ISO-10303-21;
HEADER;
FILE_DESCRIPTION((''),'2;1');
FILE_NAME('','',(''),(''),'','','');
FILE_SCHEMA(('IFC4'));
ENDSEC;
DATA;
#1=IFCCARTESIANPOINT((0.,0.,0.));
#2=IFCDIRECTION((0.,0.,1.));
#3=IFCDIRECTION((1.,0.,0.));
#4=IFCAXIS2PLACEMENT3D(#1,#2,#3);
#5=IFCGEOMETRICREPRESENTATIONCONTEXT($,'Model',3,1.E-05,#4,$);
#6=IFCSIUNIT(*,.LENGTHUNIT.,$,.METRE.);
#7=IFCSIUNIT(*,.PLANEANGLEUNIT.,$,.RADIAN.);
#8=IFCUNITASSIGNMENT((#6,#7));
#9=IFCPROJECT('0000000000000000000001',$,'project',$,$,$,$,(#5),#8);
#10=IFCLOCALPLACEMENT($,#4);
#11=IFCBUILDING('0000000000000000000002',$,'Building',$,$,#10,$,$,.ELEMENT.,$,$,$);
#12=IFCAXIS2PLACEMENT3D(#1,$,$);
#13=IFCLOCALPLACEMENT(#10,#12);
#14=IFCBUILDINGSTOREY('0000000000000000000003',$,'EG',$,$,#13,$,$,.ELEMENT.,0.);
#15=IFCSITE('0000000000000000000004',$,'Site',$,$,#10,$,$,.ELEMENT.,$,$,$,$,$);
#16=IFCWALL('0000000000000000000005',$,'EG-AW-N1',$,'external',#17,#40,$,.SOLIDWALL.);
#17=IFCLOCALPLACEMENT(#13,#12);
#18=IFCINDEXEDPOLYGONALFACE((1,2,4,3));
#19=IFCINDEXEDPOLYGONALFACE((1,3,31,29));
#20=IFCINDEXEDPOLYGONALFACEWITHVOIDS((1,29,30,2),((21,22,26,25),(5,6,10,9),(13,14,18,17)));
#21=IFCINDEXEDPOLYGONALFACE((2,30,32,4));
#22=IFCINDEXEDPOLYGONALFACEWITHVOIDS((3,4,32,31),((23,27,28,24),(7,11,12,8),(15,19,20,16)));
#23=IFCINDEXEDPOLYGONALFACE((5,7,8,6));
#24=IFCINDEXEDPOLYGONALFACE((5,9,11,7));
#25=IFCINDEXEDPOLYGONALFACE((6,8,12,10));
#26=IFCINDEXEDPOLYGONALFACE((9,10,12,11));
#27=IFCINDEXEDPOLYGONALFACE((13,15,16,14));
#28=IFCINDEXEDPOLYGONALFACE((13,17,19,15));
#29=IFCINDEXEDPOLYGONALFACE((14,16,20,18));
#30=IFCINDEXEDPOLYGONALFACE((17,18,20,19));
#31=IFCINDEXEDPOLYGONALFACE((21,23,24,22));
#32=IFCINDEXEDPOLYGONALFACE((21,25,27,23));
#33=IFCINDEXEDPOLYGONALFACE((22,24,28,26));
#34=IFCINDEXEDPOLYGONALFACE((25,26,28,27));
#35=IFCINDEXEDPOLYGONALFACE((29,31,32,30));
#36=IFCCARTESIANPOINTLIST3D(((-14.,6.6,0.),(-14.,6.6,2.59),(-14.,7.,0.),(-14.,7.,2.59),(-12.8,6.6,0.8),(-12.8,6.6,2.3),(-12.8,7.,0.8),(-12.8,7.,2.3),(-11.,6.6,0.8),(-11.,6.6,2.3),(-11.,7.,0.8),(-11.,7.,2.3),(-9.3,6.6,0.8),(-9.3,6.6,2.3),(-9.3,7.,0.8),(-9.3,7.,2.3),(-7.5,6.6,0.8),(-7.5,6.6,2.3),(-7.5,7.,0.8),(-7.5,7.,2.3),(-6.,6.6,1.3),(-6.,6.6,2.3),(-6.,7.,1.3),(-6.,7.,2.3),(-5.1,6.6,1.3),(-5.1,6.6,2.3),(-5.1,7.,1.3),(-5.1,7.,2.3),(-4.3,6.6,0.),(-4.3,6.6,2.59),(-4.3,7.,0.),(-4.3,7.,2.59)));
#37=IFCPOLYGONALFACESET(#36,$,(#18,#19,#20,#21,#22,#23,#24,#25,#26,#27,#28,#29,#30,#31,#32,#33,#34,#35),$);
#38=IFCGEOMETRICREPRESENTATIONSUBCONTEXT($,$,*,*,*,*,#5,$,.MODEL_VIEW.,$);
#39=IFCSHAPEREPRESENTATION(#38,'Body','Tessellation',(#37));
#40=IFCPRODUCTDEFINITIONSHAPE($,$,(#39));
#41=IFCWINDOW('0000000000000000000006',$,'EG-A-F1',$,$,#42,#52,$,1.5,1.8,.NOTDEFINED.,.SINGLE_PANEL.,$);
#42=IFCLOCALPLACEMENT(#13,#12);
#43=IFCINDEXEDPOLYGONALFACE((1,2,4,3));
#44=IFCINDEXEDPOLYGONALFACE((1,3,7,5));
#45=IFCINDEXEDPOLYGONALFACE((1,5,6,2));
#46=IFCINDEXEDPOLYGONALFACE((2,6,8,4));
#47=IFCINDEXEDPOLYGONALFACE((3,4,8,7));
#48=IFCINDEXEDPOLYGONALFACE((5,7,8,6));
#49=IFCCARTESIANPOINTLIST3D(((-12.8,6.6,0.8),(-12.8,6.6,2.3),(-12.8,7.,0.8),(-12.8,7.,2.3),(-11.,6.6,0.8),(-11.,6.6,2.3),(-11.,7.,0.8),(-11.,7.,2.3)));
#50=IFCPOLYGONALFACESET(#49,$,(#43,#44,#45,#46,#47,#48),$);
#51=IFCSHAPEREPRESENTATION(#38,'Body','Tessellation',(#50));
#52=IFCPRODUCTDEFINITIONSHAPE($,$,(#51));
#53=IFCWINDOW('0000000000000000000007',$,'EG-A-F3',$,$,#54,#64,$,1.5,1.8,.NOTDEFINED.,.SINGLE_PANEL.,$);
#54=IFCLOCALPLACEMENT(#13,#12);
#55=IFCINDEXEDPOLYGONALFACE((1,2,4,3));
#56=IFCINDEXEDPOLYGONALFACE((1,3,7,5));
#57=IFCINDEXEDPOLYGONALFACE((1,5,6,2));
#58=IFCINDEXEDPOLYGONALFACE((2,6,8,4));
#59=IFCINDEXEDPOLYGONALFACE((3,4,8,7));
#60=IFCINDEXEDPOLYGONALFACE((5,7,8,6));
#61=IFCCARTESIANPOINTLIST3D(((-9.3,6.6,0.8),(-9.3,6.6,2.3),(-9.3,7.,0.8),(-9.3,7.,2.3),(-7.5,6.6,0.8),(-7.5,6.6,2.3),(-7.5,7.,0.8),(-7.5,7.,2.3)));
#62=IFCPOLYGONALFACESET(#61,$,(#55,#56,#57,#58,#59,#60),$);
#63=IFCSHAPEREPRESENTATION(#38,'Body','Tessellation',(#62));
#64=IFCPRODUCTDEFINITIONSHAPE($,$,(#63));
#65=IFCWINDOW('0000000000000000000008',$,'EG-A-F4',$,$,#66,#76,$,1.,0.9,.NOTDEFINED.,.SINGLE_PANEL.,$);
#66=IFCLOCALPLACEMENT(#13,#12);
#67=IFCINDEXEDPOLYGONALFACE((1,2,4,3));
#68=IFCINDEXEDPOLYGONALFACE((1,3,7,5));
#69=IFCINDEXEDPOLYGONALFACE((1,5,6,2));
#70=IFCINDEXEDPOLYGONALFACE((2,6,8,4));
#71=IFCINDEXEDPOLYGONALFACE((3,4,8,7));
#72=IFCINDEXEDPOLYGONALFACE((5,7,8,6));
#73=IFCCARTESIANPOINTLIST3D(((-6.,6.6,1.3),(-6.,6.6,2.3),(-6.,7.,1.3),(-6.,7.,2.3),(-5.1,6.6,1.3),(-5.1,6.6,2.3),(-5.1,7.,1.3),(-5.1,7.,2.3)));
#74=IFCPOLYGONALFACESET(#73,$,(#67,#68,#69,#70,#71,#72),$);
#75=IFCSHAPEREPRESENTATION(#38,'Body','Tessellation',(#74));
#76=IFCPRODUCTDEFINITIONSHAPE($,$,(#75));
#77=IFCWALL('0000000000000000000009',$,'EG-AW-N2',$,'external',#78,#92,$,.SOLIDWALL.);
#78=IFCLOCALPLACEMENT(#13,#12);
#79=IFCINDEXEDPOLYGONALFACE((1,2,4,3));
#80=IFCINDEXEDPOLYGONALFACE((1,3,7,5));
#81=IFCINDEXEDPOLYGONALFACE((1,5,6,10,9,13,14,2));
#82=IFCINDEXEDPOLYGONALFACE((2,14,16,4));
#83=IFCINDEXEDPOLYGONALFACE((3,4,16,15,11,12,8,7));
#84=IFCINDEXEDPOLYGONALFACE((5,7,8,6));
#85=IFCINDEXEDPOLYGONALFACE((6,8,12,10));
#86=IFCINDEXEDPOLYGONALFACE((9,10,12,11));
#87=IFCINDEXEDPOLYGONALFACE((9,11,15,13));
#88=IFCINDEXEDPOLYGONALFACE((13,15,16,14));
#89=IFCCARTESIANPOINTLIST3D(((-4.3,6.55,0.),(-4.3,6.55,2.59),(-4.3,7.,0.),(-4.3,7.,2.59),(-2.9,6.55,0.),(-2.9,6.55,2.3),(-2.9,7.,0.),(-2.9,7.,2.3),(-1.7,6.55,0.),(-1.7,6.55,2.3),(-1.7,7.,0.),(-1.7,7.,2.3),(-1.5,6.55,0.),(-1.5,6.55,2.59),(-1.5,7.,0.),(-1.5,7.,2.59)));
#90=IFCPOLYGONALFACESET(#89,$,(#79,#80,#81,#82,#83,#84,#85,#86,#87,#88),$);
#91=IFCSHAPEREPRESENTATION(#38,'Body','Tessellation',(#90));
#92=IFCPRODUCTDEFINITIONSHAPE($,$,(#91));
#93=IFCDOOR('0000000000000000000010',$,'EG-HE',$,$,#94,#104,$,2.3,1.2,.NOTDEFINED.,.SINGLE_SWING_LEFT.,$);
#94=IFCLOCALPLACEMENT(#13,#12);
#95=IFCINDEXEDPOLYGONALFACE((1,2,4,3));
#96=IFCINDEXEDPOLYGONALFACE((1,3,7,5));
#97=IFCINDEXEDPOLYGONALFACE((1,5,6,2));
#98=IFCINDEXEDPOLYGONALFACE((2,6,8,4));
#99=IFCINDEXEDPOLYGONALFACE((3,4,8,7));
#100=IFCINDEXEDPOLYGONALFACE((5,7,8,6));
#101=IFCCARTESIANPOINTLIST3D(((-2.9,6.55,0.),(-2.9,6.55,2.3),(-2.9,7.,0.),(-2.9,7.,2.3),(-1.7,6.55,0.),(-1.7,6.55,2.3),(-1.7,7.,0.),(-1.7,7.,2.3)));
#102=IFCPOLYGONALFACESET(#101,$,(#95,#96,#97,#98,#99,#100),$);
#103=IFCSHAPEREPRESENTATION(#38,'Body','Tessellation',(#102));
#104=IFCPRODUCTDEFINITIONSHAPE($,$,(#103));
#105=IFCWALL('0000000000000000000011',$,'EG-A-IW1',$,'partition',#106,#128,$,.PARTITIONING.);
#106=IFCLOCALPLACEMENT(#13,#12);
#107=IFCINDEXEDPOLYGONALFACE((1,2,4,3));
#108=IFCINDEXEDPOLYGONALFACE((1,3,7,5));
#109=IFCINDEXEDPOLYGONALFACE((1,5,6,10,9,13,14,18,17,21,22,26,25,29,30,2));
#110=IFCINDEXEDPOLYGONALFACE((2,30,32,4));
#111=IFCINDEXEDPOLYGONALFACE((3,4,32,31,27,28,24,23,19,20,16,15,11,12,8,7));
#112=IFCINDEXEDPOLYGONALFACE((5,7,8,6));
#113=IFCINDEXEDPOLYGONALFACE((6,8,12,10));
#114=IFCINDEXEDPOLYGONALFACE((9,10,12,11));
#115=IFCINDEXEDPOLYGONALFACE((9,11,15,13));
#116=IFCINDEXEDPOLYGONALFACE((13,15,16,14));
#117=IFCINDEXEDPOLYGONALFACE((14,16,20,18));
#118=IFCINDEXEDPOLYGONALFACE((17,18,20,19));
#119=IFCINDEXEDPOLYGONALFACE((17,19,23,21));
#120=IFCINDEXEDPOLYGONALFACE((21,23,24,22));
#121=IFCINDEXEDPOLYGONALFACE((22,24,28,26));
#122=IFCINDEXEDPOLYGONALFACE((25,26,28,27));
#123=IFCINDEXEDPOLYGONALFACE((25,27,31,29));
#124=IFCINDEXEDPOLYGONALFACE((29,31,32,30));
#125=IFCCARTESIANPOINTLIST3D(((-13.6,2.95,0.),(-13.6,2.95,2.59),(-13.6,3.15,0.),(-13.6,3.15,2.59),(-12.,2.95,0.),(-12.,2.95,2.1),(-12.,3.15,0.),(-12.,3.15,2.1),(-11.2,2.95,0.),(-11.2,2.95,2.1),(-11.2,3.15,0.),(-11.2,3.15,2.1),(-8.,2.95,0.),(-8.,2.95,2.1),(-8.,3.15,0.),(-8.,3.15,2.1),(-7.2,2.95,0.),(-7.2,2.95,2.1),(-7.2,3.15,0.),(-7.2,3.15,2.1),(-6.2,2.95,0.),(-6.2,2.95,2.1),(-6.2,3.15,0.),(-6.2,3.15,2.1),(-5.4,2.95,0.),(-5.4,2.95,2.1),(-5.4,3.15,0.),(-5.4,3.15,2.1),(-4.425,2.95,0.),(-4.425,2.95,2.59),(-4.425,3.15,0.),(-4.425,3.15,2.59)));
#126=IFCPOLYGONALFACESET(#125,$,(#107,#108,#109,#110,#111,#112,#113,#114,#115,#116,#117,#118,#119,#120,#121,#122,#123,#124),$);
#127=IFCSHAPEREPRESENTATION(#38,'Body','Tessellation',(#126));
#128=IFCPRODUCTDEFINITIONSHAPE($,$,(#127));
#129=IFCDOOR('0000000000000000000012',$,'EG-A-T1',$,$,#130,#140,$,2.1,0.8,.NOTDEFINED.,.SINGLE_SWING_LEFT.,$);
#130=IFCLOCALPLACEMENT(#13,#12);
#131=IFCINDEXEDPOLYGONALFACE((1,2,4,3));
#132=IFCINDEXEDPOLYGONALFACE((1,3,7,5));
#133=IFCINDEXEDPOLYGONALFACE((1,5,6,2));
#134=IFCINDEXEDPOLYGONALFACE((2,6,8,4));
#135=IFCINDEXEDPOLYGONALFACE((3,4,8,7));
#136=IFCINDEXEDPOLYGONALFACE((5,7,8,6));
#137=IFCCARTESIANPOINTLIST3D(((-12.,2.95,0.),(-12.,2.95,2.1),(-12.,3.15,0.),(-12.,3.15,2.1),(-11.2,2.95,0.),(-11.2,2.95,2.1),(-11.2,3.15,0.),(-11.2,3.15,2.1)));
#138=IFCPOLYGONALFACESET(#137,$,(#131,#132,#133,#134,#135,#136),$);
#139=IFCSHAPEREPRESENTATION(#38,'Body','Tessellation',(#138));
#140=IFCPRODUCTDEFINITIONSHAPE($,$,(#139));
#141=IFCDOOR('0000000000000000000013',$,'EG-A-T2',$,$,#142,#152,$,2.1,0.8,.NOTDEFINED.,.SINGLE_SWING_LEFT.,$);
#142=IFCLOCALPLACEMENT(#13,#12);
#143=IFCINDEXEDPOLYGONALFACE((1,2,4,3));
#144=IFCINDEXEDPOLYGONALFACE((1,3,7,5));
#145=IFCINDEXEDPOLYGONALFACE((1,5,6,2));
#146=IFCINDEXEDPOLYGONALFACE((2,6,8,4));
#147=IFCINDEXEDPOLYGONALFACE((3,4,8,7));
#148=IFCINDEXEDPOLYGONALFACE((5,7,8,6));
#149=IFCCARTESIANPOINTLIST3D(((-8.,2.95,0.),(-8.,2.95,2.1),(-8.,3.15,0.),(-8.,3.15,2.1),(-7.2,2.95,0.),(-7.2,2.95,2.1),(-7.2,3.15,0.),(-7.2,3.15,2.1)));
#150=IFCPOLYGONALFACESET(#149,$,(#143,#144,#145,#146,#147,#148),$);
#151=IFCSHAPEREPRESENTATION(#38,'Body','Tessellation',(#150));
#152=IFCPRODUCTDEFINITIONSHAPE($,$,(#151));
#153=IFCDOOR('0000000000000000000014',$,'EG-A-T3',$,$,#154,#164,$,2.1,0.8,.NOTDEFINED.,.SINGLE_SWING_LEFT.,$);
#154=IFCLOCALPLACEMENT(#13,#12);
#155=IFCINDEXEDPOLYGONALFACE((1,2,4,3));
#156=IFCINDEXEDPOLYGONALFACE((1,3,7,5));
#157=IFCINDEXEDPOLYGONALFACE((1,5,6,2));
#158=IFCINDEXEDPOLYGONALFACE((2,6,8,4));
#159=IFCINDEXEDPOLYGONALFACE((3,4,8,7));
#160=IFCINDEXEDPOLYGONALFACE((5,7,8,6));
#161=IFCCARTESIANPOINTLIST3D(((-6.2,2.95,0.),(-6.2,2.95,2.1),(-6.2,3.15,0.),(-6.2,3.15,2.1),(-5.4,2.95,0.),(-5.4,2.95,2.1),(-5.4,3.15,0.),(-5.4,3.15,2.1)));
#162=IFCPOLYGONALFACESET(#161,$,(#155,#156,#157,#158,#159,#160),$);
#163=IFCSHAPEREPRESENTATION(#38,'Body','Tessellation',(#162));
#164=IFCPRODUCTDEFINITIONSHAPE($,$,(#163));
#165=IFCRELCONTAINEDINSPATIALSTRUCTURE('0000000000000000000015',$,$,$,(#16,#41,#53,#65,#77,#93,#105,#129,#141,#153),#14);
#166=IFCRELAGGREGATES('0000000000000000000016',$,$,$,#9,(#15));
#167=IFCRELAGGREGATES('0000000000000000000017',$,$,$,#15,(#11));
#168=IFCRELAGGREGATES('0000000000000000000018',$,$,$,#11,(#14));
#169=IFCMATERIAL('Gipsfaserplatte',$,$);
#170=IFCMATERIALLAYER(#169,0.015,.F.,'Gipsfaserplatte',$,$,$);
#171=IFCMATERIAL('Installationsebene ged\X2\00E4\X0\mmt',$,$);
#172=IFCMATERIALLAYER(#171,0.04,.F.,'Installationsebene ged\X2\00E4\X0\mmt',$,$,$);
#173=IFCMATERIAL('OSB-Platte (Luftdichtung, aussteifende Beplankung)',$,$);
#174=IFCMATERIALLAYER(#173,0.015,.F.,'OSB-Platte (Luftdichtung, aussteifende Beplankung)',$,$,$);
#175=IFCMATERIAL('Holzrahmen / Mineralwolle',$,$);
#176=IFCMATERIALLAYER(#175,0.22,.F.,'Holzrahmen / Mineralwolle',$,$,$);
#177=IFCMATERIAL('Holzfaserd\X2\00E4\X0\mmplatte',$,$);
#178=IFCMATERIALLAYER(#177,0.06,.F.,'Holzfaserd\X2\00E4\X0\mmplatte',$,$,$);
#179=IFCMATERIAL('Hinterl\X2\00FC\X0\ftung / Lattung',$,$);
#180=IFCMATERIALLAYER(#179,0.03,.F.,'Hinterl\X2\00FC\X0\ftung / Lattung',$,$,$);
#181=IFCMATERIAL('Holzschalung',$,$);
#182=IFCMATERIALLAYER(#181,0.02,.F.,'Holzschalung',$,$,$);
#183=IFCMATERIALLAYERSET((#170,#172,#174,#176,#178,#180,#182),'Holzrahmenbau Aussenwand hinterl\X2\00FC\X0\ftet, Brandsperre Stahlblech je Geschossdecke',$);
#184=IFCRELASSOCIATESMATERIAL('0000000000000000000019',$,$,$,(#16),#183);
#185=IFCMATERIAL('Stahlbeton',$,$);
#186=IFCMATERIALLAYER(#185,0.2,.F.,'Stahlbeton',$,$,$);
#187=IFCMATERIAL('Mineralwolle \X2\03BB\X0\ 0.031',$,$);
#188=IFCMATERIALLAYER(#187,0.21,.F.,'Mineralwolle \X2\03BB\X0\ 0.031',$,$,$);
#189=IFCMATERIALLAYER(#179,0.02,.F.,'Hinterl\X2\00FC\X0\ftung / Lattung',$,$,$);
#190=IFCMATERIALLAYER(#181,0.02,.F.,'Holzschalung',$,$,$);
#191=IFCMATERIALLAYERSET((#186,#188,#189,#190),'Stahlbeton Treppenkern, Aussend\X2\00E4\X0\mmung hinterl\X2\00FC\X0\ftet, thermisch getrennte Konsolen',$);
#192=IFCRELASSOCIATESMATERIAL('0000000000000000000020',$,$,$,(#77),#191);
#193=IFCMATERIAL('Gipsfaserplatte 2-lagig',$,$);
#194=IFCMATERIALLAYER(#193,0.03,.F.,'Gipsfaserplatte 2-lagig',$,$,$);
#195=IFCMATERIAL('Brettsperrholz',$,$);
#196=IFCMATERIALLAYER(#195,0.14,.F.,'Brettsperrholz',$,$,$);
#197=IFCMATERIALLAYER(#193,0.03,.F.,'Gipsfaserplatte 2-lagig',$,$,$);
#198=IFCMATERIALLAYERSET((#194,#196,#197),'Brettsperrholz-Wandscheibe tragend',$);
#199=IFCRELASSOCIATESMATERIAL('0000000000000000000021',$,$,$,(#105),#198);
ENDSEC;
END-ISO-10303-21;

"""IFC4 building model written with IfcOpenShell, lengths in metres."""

from ifc_helpers import new_model, si_unit, frame, frame_2d, origin, origin_with_axes, place, context, subcontext, project, spatial, rectangle, extrude, material, layer, layer_set, element, fill, save


model = new_model("IFC4")

# Units and contexts
model_context = context("Model", 3, precision=1e-05, world=origin_with_axes())
sub_context = subcontext(model_context, None, None, "MODEL_VIEW")
ifc_project = project(units=[si_unit("LENGTHUNIT", "METRE"), si_unit("PLANEANGLEUNIT", "RADIAN")], contexts=[model_context])

# Site, building, storey
placement = place(None, origin_with_axes())
site = spatial("IfcSite", under=ifc_project, at=placement, Name="Site", CompositionType="ELEMENT")
building = spatial("IfcBuilding", under=site, at=placement, Name="Building", CompositionType="ELEMENT")
storey_placement = place(placement, origin())
storey = spatial("IfcBuildingStorey", under=building, at=storey_placement, Name="EG", CompositionType="ELEMENT", Elevation=0.0)

# Wall, openings, windows
ifc_material_1 = material(Name="Gipsfaserplatte")
ifc_layer_1 = layer(ifc_material_1, 0.015, ventilated=False, Name="Gipsfaserplatte")
ifc_material_2 = material(Name="Installationsebene gedämmt")
ifc_layer_2 = layer(ifc_material_2, 0.04, ventilated=False, Name="Installationsebene gedämmt")
ifc_material_3 = material(Name="OSB-Platte (Luftdichtung, aussteifende Beplankung)")
ifc_layer_3 = layer(ifc_material_3, 0.015, ventilated=False, Name="OSB-Platte (Luftdichtung, aussteifende Beplankung)")
ifc_material_4 = material(Name="Holzrahmen / Mineralwolle")
ifc_layer_4 = layer(ifc_material_4, 0.22, ventilated=False, Name="Holzrahmen / Mineralwolle")
ifc_material_5 = material(Name="Holzfaserdämmplatte")
ifc_layer_5 = layer(ifc_material_5, 0.06, ventilated=False, Name="Holzfaserdämmplatte")
ifc_material_6 = material(Name="Hinterlüftung / Lattung")
ifc_layer_6 = layer(ifc_material_6, 0.03, ventilated=False, Name="Hinterlüftung / Lattung")
ifc_material_7 = material(Name="Holzschalung")
ifc_layer_7 = layer(ifc_material_7, 0.02, ventilated=False, Name="Holzschalung")
ifc_layer_set_1 = layer_set([ifc_layer_1, ifc_layer_2, ifc_layer_3, ifc_layer_4, ifc_layer_5, ifc_layer_6, ifc_layer_7], Name="Holzrahmenbau Aussenwand hinterlüftet, Brandsperre Stahlblech je Geschossdecke")
wall_1_placement = place(storey_placement, frame((-14.0, 6.8, 0.0), z_axis=(0.0, 0.0, 1.0), x_axis=(1.0, 0.0, 0.0)))
wall_1 = element("IfcWall", 1, at=wall_1_placement, inside=storey, material=ifc_layer_set_1, Name="EG-AW-N1", ObjectType="external", PredefinedType="SOLIDWALL", context=sub_context, shape_type="SweptSolid", body=[
    extrude(rectangle(XDim=9.7, YDim=0.4, at=frame_2d((4.85, 0.0))), origin(), (0.0, 0.0, 1.0), 2.59),
])
opening_1_placement = place(wall_1_placement, frame((2.1, 0.25, 0.8), z_axis=(0.0, -1.0, 0.0), x_axis=(1.0, 0.0, 0.0)))
opening_1 = element("IfcOpeningElement", 2, at=opening_1_placement, cuts=wall_1, PredefinedType="OPENING", context=sub_context, shape_type="SweptSolid", body=[
    extrude(rectangle(XDim=1.8, YDim=1.5, at=frame_2d((0.0, 0.75))), origin(), (0.0, 0.0, 1.0), 0.5),
])
opening_2_placement = place(wall_1_placement, frame((5.6, 0.25, 0.8), z_axis=(0.0, -1.0, 0.0), x_axis=(1.0, 0.0, 0.0)))
opening_2 = element("IfcOpeningElement", 3, at=opening_2_placement, cuts=wall_1, PredefinedType="OPENING", context=sub_context, shape_type="SweptSolid", body=[
    extrude(rectangle(XDim=1.8, YDim=1.5, at=frame_2d((0.0, 0.75))), origin(), (0.0, 0.0, 1.0), 0.5),
])
opening_3_placement = place(wall_1_placement, frame((8.45, 0.25, 1.3), z_axis=(0.0, -1.0, 0.0), x_axis=(1.0, 0.0, 0.0)))
opening_3 = element("IfcOpeningElement", 4, at=opening_3_placement, cuts=wall_1, PredefinedType="OPENING", context=sub_context, shape_type="SweptSolid", body=[
    extrude(rectangle(XDim=0.9, YDim=1.0, at=frame_2d((0.0, 0.5))), origin(), (0.0, 0.0, 1.0), 0.5),
])
window_1_placement = place(wall_1_placement, frame((2.1, 0.2, 0.8), z_axis=(0.0, -1.0, 0.0), x_axis=(1.0, 0.0, 0.0)))
window_1 = element("IfcWindow", 5, at=window_1_placement, inside=storey, Name="EG-A-F1", OverallHeight=1.5, OverallWidth=1.8, PartitioningType="SINGLE_PANEL", PredefinedType="NOTDEFINED", context=sub_context, shape_type="SweptSolid", body=[
    extrude(rectangle(XDim=1.8, YDim=1.5, at=frame_2d((0.0, 0.75))), origin(), (0.0, 0.0, 1.0), 0.4),
])
fill(opening_1, window_1)
window_2_placement = place(wall_1_placement, frame((5.6, 0.2, 0.8), z_axis=(0.0, -1.0, 0.0), x_axis=(1.0, 0.0, 0.0)))
window_2 = element("IfcWindow", 6, at=window_2_placement, inside=storey, Name="EG-A-F3", OverallHeight=1.5, OverallWidth=1.8, PartitioningType="SINGLE_PANEL", PredefinedType="NOTDEFINED", context=sub_context, shape_type="SweptSolid", body=[
    extrude(rectangle(XDim=1.8, YDim=1.5, at=frame_2d((0.0, 0.75))), origin(), (0.0, 0.0, 1.0), 0.4),
])
fill(opening_2, window_2)
window_3_placement = place(wall_1_placement, frame((8.45, 0.2, 1.3), z_axis=(0.0, -1.0, 0.0), x_axis=(1.0, 0.0, 0.0)))
window_3 = element("IfcWindow", 7, at=window_3_placement, inside=storey, Name="EG-A-F4", OverallHeight=1.0, OverallWidth=0.9, PartitioningType="SINGLE_PANEL", PredefinedType="NOTDEFINED", context=sub_context, shape_type="SweptSolid", body=[
    extrude(rectangle(XDim=0.9, YDim=1.0, at=frame_2d((0.0, 0.5))), origin(), (0.0, 0.0, 1.0), 0.4),
])
fill(opening_3, window_3)

# Wall, opening, door
ifc_material_8 = material(Name="Stahlbeton")
ifc_layer_8 = layer(ifc_material_8, 0.2, ventilated=False, Name="Stahlbeton")
ifc_material_9 = material(Name="Mineralwolle λ 0.031")
ifc_layer_9 = layer(ifc_material_9, 0.21, ventilated=False, Name="Mineralwolle λ 0.031")
ifc_layer_10 = layer(ifc_material_6, 0.02, ventilated=False, Name="Hinterlüftung / Lattung")
ifc_layer_11 = layer(ifc_material_7, 0.02, ventilated=False, Name="Holzschalung")
ifc_layer_set_2 = layer_set([ifc_layer_8, ifc_layer_9, ifc_layer_10, ifc_layer_11], Name="Stahlbeton Treppenkern, Aussendämmung hinterlüftet, thermisch getrennte Konsolen")
wall_2_placement = place(storey_placement, frame((-4.3, 6.775, 0.0), z_axis=(0.0, 0.0, 1.0), x_axis=(1.0, 0.0, 0.0)))
wall_2 = element("IfcWall", 8, at=wall_2_placement, inside=storey, material=ifc_layer_set_2, Name="EG-AW-N2", ObjectType="external", PredefinedType="SOLIDWALL", context=sub_context, shape_type="SweptSolid", body=[
    extrude(rectangle(XDim=2.8, YDim=0.45, at=frame_2d((1.4, 0.0))), origin(), (0.0, 0.0, 1.0), 2.59),
])
opening_4_placement = place(wall_2_placement, frame((2.0, 0.275, 0.0), z_axis=(0.0, -1.0, 0.0), x_axis=(1.0, 0.0, 0.0)))
opening_4 = element("IfcOpeningElement", 9, at=opening_4_placement, cuts=wall_2, PredefinedType="OPENING", context=sub_context, shape_type="SweptSolid", body=[
    extrude(rectangle(XDim=1.2, YDim=2.3, at=frame_2d((0.0, 1.15))), origin(), (0.0, 0.0, 1.0), 0.55),
])
door_1_placement = place(wall_2_placement, frame((2.0, 0.225, 0.0), z_axis=(0.0, -1.0, 0.0), x_axis=(1.0, 0.0, 0.0)))
door_1 = element("IfcDoor", 10, at=door_1_placement, inside=storey, Name="EG-HE", OperationType="SINGLE_SWING_LEFT", OverallHeight=2.3, OverallWidth=1.2, PredefinedType="NOTDEFINED", context=sub_context, shape_type="SweptSolid", body=[
    extrude(rectangle(XDim=1.2, YDim=2.3, at=frame_2d((0.0, 1.15))), origin(), (0.0, 0.0, 1.0), 0.45),
])
fill(opening_4, door_1)

# Wall, openings, doors
ifc_material_10 = material(Name="Gipsfaserplatte 2-lagig")
ifc_layer_12 = layer(ifc_material_10, 0.03, ventilated=False, Name="Gipsfaserplatte 2-lagig")
ifc_material_11 = material(Name="Brettsperrholz")
ifc_layer_13 = layer(ifc_material_11, 0.14, ventilated=False, Name="Brettsperrholz")
ifc_layer_14 = layer(ifc_material_10, 0.03, ventilated=False, Name="Gipsfaserplatte 2-lagig")
ifc_layer_set_3 = layer_set([ifc_layer_12, ifc_layer_13, ifc_layer_14], Name="Brettsperrholz-Wandscheibe tragend")
wall_3_placement = place(storey_placement, frame((-13.6, 3.05, 0.0), z_axis=(0.0, 0.0, 1.0), x_axis=(1.0, 0.0, 0.0)))
wall_3 = element("IfcWall", 11, at=wall_3_placement, inside=storey, material=ifc_layer_set_3, Name="EG-A-IW1", ObjectType="partition", PredefinedType="PARTITIONING", context=sub_context, shape_type="SweptSolid", body=[
    extrude(rectangle(XDim=9.175, YDim=0.2, at=frame_2d((4.5875, 0.0))), origin(), (0.0, 0.0, 1.0), 2.59),
])
opening_5_placement = place(wall_3_placement, frame((2.0, 0.15, 0.0), z_axis=(0.0, -1.0, 0.0), x_axis=(1.0, 0.0, 0.0)))
opening_5 = element("IfcOpeningElement", 12, at=opening_5_placement, cuts=wall_3, PredefinedType="OPENING", context=sub_context, shape_type="SweptSolid", body=[
    extrude(rectangle(XDim=0.8, YDim=2.1, at=frame_2d((0.0, 1.05))), origin(), (0.0, 0.0, 1.0), 0.3),
])
opening_6_placement = place(wall_3_placement, frame((6.0, 0.15, 0.0), z_axis=(0.0, -1.0, 0.0), x_axis=(1.0, 0.0, 0.0)))
opening_6 = element("IfcOpeningElement", 13, at=opening_6_placement, cuts=wall_3, PredefinedType="OPENING", context=sub_context, shape_type="SweptSolid", body=[
    extrude(rectangle(XDim=0.8, YDim=2.1, at=frame_2d((0.0, 1.05))), origin(), (0.0, 0.0, 1.0), 0.3),
])
opening_7_placement = place(wall_3_placement, frame((7.8, 0.15, 0.0), z_axis=(0.0, -1.0, 0.0), x_axis=(1.0, 0.0, 0.0)))
opening_7 = element("IfcOpeningElement", 14, at=opening_7_placement, cuts=wall_3, PredefinedType="OPENING", context=sub_context, shape_type="SweptSolid", body=[
    extrude(rectangle(XDim=0.8, YDim=2.1, at=frame_2d((0.0, 1.05))), origin(), (0.0, 0.0, 1.0), 0.3),
])
door_2_placement = place(wall_3_placement, frame((2.0, 0.1, 0.0), z_axis=(0.0, -1.0, 0.0), x_axis=(1.0, 0.0, 0.0)))
door_2 = element("IfcDoor", 15, at=door_2_placement, inside=storey, Name="EG-A-T1", OperationType="SINGLE_SWING_LEFT", OverallHeight=2.1, OverallWidth=0.8, PredefinedType="NOTDEFINED", context=sub_context, shape_type="SweptSolid", body=[
    extrude(rectangle(XDim=0.8, YDim=2.1, at=frame_2d((0.0, 1.05))), origin(), (0.0, 0.0, 1.0), 0.2),
])
fill(opening_5, door_2)
door_3_placement = place(wall_3_placement, frame((6.0, 0.1, 0.0), z_axis=(0.0, -1.0, 0.0), x_axis=(1.0, 0.0, 0.0)))
door_3 = element("IfcDoor", 16, at=door_3_placement, inside=storey, Name="EG-A-T2", OperationType="SINGLE_SWING_LEFT", OverallHeight=2.1, OverallWidth=0.8, PredefinedType="NOTDEFINED", context=sub_context, shape_type="SweptSolid", body=[
    extrude(rectangle(XDim=0.8, YDim=2.1, at=frame_2d((0.0, 1.05))), origin(), (0.0, 0.0, 1.0), 0.2),
])
fill(opening_6, door_3)
door_4_placement = place(wall_3_placement, frame((7.8, 0.1, 0.0), z_axis=(0.0, -1.0, 0.0), x_axis=(1.0, 0.0, 0.0)))
door_4 = element("IfcDoor", 17, at=door_4_placement, inside=storey, Name="EG-A-T3", OperationType="SINGLE_SWING_LEFT", OverallHeight=2.1, OverallWidth=0.8, PredefinedType="NOTDEFINED", context=sub_context, shape_type="SweptSolid", body=[
    extrude(rectangle(XDim=0.8, YDim=2.1, at=frame_2d((0.0, 1.05))), origin(), (0.0, 0.0, 1.0), 0.2),
])
fill(opening_7, door_4)

save(model, "model.ifc")
